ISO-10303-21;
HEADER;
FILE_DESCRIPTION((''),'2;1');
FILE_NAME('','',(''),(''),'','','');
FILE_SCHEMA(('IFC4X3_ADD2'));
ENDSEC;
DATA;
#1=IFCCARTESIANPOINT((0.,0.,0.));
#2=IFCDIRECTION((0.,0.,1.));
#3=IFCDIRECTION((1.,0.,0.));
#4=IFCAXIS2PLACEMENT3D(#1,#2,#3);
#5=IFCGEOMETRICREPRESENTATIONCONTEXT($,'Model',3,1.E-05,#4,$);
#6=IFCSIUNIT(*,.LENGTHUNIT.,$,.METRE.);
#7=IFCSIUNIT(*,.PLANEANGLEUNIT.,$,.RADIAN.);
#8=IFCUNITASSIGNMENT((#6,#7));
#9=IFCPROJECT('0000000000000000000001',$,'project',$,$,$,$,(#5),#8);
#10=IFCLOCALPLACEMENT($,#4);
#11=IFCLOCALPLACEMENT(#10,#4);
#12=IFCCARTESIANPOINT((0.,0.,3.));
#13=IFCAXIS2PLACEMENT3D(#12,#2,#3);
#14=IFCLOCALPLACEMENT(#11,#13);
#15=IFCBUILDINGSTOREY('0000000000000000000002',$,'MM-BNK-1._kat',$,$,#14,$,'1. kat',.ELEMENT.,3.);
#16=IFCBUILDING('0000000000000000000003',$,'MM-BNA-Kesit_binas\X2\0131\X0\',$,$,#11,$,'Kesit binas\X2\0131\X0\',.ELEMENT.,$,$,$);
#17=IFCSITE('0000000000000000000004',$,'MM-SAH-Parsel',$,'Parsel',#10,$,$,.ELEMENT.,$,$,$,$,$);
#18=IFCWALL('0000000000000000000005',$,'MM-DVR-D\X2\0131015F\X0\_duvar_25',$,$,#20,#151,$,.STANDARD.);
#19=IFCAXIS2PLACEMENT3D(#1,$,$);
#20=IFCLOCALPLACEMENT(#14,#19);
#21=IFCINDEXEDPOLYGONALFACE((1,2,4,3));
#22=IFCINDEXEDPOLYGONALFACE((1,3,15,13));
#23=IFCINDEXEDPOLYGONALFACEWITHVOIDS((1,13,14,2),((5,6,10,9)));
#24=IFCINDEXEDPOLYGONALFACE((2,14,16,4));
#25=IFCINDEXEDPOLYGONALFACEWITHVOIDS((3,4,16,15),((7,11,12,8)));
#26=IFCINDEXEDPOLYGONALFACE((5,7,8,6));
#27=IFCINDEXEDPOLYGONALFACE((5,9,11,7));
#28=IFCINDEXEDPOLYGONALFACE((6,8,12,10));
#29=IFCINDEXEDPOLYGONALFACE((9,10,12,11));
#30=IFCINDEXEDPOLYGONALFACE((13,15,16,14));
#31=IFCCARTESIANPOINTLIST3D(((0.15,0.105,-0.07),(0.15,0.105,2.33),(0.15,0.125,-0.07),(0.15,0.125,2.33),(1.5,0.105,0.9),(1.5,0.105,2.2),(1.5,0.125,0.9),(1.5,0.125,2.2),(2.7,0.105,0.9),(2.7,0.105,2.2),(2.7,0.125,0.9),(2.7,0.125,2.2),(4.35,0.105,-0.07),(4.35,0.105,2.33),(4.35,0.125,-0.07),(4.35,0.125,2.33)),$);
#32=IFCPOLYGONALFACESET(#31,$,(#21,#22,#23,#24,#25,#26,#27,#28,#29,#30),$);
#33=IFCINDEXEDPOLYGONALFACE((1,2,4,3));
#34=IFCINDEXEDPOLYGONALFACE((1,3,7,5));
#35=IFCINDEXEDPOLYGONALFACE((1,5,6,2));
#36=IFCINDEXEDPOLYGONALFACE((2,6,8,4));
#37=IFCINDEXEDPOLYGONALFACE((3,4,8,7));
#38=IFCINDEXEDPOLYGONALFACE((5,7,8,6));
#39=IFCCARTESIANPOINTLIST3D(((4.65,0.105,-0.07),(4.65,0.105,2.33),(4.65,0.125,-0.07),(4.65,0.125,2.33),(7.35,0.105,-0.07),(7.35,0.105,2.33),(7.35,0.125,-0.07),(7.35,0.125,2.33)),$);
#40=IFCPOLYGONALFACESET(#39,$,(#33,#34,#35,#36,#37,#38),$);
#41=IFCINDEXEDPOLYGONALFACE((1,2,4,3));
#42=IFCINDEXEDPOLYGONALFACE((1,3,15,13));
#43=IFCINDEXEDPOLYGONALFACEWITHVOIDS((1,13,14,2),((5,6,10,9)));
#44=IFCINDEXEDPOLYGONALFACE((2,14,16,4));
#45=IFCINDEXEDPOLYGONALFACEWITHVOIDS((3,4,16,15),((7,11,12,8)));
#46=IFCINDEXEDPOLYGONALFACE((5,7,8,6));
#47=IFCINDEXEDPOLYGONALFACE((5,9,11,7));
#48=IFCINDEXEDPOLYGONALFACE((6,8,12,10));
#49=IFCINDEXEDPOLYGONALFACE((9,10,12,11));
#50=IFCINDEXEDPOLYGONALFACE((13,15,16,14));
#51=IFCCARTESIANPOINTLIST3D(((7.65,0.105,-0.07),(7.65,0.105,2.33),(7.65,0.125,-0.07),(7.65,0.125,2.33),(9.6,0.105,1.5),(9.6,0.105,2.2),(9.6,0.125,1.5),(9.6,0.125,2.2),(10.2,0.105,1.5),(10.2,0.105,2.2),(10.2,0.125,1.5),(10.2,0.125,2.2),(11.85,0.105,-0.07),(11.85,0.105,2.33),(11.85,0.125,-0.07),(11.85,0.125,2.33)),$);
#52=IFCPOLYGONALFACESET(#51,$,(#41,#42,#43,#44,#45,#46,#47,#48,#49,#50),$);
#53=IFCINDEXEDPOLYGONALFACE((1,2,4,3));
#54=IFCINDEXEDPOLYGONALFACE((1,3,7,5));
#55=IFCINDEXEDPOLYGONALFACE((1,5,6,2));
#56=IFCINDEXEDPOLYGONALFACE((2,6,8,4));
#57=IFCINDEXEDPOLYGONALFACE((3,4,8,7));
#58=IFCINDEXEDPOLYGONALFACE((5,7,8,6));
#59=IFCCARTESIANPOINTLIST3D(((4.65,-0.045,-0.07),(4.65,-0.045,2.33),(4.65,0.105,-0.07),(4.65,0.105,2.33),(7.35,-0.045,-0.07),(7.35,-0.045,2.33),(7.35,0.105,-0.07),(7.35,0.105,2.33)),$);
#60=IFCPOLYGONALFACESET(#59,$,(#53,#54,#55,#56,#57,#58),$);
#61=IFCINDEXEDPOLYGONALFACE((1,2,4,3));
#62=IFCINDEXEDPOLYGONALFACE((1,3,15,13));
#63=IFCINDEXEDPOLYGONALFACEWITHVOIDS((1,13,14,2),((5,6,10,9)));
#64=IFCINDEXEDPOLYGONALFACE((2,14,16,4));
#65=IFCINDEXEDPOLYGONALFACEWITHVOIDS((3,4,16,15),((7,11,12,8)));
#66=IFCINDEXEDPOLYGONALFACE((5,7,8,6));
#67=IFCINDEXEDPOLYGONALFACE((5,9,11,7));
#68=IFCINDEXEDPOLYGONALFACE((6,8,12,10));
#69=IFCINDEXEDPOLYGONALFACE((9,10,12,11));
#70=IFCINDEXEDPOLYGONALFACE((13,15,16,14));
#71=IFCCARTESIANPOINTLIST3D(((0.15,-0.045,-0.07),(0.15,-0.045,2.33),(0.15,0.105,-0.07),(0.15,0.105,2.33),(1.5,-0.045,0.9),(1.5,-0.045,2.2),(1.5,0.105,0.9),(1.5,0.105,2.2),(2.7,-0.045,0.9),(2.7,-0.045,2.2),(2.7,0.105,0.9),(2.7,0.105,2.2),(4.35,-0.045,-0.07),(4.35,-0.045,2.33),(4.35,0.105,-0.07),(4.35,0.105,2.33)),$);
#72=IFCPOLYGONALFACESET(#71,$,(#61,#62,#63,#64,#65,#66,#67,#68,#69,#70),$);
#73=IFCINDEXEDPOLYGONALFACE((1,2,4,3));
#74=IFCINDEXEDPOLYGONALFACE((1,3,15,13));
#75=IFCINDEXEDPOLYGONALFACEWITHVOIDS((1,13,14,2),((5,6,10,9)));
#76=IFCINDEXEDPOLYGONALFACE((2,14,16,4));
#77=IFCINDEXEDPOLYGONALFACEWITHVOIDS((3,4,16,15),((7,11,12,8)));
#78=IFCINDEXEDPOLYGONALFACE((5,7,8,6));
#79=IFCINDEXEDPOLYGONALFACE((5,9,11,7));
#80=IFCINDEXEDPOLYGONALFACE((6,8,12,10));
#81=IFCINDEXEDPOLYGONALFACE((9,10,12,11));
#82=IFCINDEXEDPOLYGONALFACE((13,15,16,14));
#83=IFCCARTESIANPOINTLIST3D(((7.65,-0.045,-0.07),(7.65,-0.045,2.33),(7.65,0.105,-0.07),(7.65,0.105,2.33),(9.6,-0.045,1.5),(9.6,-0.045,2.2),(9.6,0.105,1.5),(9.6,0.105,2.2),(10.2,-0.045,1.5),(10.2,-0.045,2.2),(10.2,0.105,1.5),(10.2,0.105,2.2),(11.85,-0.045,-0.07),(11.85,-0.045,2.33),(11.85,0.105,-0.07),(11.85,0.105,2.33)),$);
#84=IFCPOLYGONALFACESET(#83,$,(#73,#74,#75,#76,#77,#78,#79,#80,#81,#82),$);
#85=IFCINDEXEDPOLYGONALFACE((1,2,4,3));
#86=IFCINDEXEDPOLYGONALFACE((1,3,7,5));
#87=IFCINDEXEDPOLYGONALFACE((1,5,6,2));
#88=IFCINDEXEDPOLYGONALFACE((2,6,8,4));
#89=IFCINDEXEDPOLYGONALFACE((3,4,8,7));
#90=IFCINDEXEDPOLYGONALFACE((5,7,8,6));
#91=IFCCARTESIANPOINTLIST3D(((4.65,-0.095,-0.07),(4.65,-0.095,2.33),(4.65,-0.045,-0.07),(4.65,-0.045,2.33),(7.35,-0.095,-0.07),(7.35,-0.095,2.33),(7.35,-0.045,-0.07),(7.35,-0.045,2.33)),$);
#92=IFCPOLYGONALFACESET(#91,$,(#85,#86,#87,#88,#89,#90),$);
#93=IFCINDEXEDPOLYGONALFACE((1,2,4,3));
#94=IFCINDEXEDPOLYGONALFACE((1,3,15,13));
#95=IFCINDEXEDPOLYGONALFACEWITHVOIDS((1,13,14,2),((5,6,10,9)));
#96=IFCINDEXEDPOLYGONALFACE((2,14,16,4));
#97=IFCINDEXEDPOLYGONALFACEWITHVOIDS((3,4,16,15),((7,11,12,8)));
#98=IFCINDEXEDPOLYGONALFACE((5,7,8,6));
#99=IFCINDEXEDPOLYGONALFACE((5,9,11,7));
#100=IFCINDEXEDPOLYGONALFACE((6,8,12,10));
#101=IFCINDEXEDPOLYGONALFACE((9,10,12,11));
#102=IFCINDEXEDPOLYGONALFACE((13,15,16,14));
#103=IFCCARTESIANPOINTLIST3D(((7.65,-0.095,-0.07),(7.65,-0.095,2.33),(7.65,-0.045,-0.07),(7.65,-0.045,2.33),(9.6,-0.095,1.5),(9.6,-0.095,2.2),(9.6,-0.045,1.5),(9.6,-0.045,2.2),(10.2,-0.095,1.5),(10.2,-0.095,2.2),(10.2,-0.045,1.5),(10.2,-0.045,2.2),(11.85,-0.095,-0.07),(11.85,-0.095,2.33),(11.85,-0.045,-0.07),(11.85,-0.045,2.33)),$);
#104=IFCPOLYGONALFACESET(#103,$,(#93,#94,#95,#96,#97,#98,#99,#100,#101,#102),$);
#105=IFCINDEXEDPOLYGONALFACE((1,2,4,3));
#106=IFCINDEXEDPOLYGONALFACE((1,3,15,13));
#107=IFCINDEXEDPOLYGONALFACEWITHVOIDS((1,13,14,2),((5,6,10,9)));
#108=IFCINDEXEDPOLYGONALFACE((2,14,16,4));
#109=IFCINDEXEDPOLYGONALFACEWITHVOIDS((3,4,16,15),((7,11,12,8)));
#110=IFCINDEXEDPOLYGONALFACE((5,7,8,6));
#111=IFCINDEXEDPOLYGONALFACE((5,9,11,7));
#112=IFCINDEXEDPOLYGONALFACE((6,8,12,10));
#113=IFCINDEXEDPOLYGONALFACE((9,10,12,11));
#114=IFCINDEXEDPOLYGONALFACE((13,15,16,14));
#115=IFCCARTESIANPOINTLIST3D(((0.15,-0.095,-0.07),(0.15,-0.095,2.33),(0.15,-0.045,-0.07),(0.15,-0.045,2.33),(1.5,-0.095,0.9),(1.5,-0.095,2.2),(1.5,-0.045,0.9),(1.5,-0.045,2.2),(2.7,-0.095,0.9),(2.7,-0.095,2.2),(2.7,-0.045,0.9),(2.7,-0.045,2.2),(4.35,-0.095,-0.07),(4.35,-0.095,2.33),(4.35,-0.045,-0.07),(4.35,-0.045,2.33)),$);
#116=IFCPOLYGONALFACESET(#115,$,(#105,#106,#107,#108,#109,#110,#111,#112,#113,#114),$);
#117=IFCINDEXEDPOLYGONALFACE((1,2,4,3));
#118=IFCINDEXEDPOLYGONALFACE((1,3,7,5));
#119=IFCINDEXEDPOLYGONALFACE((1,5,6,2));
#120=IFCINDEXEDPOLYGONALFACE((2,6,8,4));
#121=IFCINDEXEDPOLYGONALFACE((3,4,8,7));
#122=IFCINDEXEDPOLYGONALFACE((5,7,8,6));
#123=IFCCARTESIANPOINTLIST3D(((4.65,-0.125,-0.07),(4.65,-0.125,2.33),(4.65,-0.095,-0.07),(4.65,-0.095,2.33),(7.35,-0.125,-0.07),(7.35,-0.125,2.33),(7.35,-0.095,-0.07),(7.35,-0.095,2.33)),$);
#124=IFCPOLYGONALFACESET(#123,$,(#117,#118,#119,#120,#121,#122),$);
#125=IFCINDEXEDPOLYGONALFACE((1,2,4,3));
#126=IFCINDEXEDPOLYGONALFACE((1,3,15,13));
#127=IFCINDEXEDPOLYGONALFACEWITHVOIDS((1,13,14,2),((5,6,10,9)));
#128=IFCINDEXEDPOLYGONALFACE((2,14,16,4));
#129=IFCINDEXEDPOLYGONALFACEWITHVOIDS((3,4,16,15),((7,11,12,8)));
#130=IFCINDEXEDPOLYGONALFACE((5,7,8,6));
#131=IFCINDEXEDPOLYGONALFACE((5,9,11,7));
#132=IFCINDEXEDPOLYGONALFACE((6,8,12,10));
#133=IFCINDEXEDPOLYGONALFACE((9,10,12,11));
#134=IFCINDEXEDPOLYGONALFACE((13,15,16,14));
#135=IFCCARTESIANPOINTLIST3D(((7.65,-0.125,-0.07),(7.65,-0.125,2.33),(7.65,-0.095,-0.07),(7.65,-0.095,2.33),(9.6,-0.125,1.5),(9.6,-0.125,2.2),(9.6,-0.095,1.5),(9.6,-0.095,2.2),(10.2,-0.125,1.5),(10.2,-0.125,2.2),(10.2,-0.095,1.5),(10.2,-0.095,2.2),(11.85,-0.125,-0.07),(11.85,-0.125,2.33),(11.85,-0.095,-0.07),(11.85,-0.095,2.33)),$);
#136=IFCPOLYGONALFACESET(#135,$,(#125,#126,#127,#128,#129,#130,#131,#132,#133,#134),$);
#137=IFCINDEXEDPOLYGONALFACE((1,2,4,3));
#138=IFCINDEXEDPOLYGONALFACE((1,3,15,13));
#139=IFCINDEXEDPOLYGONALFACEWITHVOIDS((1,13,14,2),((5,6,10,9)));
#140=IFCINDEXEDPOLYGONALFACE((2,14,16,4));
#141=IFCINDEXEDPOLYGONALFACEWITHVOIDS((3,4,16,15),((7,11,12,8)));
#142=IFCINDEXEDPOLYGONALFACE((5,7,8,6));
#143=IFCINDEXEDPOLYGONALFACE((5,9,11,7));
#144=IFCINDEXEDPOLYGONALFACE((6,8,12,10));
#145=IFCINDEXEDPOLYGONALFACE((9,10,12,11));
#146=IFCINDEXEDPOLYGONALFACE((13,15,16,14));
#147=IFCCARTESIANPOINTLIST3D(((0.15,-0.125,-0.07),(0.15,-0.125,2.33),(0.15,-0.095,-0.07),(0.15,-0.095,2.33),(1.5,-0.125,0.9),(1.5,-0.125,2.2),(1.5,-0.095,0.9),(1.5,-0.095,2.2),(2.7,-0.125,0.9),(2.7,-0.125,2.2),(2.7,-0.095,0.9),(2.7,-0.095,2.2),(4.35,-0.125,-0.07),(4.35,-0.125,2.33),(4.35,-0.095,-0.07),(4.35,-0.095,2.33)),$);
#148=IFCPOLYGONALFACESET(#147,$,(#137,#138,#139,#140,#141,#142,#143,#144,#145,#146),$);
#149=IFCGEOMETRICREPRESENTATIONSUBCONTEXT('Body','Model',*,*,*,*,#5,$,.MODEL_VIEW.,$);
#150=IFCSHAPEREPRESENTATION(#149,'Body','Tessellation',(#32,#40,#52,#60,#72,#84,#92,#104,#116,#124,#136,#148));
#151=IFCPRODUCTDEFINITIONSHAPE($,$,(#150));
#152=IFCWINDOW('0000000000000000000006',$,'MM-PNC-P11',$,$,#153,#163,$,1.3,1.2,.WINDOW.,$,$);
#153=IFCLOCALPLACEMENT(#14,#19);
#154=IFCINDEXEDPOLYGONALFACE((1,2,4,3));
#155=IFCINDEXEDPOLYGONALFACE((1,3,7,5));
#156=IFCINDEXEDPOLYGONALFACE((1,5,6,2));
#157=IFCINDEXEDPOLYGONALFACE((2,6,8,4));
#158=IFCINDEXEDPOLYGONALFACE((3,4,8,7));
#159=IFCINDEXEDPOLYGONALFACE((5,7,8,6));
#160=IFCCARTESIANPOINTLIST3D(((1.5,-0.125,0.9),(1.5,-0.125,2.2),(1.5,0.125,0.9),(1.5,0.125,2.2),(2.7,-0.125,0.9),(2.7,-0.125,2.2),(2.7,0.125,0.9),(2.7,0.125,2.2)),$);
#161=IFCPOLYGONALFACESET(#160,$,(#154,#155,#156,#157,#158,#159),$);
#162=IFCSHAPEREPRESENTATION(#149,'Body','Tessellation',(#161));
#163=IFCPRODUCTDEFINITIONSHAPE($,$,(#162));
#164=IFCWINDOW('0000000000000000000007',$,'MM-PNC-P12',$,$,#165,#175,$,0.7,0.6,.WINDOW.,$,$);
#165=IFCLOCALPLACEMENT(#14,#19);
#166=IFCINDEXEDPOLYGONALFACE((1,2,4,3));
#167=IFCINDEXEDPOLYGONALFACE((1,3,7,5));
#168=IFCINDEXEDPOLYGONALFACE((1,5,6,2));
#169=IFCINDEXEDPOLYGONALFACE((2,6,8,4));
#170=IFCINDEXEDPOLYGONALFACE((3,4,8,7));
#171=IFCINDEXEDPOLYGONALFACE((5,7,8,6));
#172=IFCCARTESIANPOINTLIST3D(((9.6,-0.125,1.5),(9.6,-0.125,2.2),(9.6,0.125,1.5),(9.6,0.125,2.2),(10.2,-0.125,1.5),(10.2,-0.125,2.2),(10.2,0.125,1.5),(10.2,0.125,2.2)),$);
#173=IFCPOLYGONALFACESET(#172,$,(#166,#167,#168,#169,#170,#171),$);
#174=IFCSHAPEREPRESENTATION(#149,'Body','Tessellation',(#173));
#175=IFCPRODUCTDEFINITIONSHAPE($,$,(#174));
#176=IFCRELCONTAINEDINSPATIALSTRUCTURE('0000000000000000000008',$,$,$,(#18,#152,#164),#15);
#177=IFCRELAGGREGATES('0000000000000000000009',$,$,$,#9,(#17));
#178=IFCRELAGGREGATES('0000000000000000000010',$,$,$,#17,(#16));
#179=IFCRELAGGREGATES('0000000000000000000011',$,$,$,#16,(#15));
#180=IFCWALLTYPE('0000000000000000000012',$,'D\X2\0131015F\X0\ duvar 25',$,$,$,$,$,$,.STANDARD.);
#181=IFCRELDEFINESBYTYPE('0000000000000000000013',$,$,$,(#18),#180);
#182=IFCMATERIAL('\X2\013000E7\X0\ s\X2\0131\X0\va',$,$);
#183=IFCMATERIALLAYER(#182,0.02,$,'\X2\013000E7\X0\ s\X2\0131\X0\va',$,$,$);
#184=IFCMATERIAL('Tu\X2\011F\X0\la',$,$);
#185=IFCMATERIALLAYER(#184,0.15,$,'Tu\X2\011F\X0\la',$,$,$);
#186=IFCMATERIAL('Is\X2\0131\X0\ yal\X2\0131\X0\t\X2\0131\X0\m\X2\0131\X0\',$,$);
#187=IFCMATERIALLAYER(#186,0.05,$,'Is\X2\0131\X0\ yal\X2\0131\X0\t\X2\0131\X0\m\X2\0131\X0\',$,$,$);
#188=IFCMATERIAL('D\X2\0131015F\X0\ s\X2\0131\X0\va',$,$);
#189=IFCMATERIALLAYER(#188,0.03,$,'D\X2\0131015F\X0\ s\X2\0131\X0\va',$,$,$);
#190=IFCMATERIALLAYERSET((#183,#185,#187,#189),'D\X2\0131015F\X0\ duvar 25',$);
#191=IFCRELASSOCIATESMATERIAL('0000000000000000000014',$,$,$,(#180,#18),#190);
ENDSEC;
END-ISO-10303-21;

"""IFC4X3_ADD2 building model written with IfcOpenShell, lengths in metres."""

from ifc_helpers import new_model, si_unit, frame, origin_with_axes, place, context, subcontext, project, spatial, polyline, outline, extrude, material, layer, layer_set, type_object, element, fill, save


model = new_model("IFC4X3_ADD2")

# Units and contexts
model_context = context("Model", 3, precision=1e-05, world=origin_with_axes())
body_context = subcontext(model_context, "Body", "Model", "MODEL_VIEW")
ifc_project = project(units=[si_unit("LENGTHUNIT", "METRE"), si_unit("PLANEANGLEUNIT", "RADIAN")], contexts=[model_context])

# Site, building, storey
site_placement = place(None, origin_with_axes())
site = spatial("IfcSite", under=ifc_project, at=site_placement, Name="MM-SAH-Parsel", ObjectType="Parsel", CompositionType="ELEMENT")
building_placement = place(site_placement, origin_with_axes())
building = spatial("IfcBuilding", under=site, at=building_placement, Name="MM-BNA-Kesit_binası", LongName="Kesit binası", CompositionType="ELEMENT")
storey_placement = place(building_placement, frame((0.0, 0.0, 3.0), z_axis=(0.0, 0.0, 1.0), x_axis=(1.0, 0.0, 0.0)))
storey = spatial("IfcBuildingStorey", under=building, at=storey_placement, Name="MM-BNK-1._kat", LongName="1. kat", CompositionType="ELEMENT", Elevation=3.0)

# Wall, openings, windows
ifc_material_1 = material(Name="İç sıva")
ifc_layer_1 = layer(ifc_material_1, 0.02, Name="İç sıva")
ifc_material_2 = material(Name="Tuğla")
ifc_layer_2 = layer(ifc_material_2, 0.15, Name="Tuğla")
ifc_material_3 = material(Name="Isı yalıtımı")
ifc_layer_3 = layer(ifc_material_3, 0.05, Name="Isı yalıtımı")
ifc_material_4 = material(Name="Dış sıva")
ifc_layer_4 = layer(ifc_material_4, 0.03, Name="Dış sıva")
ifc_layer_set_1 = layer_set([ifc_layer_1, ifc_layer_2, ifc_layer_3, ifc_layer_4], Name="Dış duvar 25")
wall_type_1 = type_object("IfcWallType", Name="Dış duvar 25", PredefinedType="STANDARD", material=ifc_layer_set_1)
wall_1_placement = place(storey_placement, origin_with_axes())
wall_1 = element("IfcWall", 1, at=wall_1_placement, inside=storey, type_object=wall_type_1, material=ifc_layer_set_1, Name="MM-DVR-Dış_duvar_25", PredefinedType="STANDARD", context=body_context, shape_type="SweptSolid", body=[
    extrude(outline(polyline([(0.15, 0.105), (4.35, 0.105), (4.35, 0.125), (0.15, 0.125), (0.15, 0.105)])), frame((0.0, 0.0, -0.07)), (0.0, 0.0, 1.0), 2.4),
    extrude(outline(polyline([(4.65, 0.105), (7.35, 0.105), (7.35, 0.125), (4.65, 0.125), (4.65, 0.105)])), frame((0.0, 0.0, -0.07)), (0.0, 0.0, 1.0), 2.4),
    extrude(outline(polyline([(7.65, 0.105), (11.85, 0.105), (11.85, 0.125), (7.65, 0.125), (7.65, 0.105)])), frame((0.0, 0.0, -0.07)), (0.0, 0.0, 1.0), 2.4),
    extrude(outline(polyline([(4.65, -0.045), (7.35, -0.045), (7.35, 0.105), (4.65, 0.105), (4.65, -0.045)])), frame((0.0, 0.0, -0.07)), (0.0, 0.0, 1.0), 2.4),
    extrude(outline(polyline([(0.15, -0.045), (4.35, -0.045), (4.35, 0.105), (0.15, 0.105), (0.15, -0.045)])), frame((0.0, 0.0, -0.07)), (0.0, 0.0, 1.0), 2.4),
    extrude(outline(polyline([(7.65, -0.045), (11.85, -0.045), (11.85, 0.105), (7.65, 0.105), (7.65, -0.045)])), frame((0.0, 0.0, -0.07)), (0.0, 0.0, 1.0), 2.4),
    extrude(outline(polyline([(4.65, -0.095), (7.35, -0.095), (7.35, -0.045), (4.65, -0.045), (4.65, -0.095)])), frame((0.0, 0.0, -0.07)), (0.0, 0.0, 1.0), 2.4),
    extrude(outline(polyline([(7.65, -0.095), (11.85, -0.095), (11.85, -0.045), (7.65, -0.045), (7.65, -0.095)])), frame((0.0, 0.0, -0.07)), (0.0, 0.0, 1.0), 2.4),
    extrude(outline(polyline([(0.15, -0.095), (4.35, -0.095), (4.35, -0.045), (0.15, -0.045), (0.15, -0.095)])), frame((0.0, 0.0, -0.07)), (0.0, 0.0, 1.0), 2.4),
    extrude(outline(polyline([(4.65, -0.125), (7.35, -0.125), (7.35, -0.095), (4.65, -0.095), (4.65, -0.125)])), frame((0.0, 0.0, -0.07)), (0.0, 0.0, 1.0), 2.4),
    extrude(outline(polyline([(7.65, -0.125), (11.85, -0.125), (11.85, -0.095), (7.65, -0.095), (7.65, -0.125)])), frame((0.0, 0.0, -0.07)), (0.0, 0.0, 1.0), 2.4),
    extrude(outline(polyline([(0.15, -0.125), (4.35, -0.125), (4.35, -0.095), (0.15, -0.095), (0.15, -0.125)])), frame((0.0, 0.0, -0.07)), (0.0, 0.0, 1.0), 2.4),
])
opening_1_placement = place(storey_placement, origin_with_axes())
opening_1 = element("IfcOpeningElement", 2, at=opening_1_placement, cuts=wall_1, PredefinedType="OPENING", context=body_context, shape_type="SweptSolid", body=[
    extrude(outline(polyline([(1.5, 0.125), (2.7, 0.125), (2.7, -0.125), (1.5, -0.125), (1.5, 0.125)])), frame((0.0, 0.0, 0.9)), (0.0, 0.0, 1.0), 1.3),
])
opening_2_placement = place(storey_placement, origin_with_axes())
opening_2 = element("IfcOpeningElement", 3, at=opening_2_placement, cuts=wall_1, PredefinedType="OPENING", context=body_context, shape_type="SweptSolid", body=[
    extrude(outline(polyline([(9.6, 0.125), (10.2, 0.125), (10.2, -0.125), (9.6, -0.125), (9.6, 0.125)])), frame((0.0, 0.0, 1.5)), (0.0, 0.0, 1.0), 0.7),
])
window_1_placement = place(storey_placement, origin_with_axes())
window_1 = element("IfcWindow", 4, at=window_1_placement, inside=storey, Name="MM-PNC-P11", OverallHeight=1.3, OverallWidth=1.2, PredefinedType="WINDOW", context=body_context, shape_type="SweptSolid", body=[
    extrude(outline(polyline([(1.5, 0.125), (2.7, 0.125), (2.7, -0.125), (1.5, -0.125), (1.5, 0.125)])), frame((0.0, 0.0, 0.9)), (0.0, 0.0, 1.0), 1.3),
])
fill(opening_1, window_1)
window_2_placement = place(storey_placement, origin_with_axes())
window_2 = element("IfcWindow", 5, at=window_2_placement, inside=storey, Name="MM-PNC-P12", OverallHeight=0.7, OverallWidth=0.6, PredefinedType="WINDOW", context=body_context, shape_type="SweptSolid", body=[
    extrude(outline(polyline([(9.6, 0.125), (10.2, 0.125), (10.2, -0.125), (9.6, -0.125), (9.6, 0.125)])), frame((0.0, 0.0, 1.5)), (0.0, 0.0, 1.0), 0.7),
])
fill(opening_2, window_2)

save(model, "model.ifc")
